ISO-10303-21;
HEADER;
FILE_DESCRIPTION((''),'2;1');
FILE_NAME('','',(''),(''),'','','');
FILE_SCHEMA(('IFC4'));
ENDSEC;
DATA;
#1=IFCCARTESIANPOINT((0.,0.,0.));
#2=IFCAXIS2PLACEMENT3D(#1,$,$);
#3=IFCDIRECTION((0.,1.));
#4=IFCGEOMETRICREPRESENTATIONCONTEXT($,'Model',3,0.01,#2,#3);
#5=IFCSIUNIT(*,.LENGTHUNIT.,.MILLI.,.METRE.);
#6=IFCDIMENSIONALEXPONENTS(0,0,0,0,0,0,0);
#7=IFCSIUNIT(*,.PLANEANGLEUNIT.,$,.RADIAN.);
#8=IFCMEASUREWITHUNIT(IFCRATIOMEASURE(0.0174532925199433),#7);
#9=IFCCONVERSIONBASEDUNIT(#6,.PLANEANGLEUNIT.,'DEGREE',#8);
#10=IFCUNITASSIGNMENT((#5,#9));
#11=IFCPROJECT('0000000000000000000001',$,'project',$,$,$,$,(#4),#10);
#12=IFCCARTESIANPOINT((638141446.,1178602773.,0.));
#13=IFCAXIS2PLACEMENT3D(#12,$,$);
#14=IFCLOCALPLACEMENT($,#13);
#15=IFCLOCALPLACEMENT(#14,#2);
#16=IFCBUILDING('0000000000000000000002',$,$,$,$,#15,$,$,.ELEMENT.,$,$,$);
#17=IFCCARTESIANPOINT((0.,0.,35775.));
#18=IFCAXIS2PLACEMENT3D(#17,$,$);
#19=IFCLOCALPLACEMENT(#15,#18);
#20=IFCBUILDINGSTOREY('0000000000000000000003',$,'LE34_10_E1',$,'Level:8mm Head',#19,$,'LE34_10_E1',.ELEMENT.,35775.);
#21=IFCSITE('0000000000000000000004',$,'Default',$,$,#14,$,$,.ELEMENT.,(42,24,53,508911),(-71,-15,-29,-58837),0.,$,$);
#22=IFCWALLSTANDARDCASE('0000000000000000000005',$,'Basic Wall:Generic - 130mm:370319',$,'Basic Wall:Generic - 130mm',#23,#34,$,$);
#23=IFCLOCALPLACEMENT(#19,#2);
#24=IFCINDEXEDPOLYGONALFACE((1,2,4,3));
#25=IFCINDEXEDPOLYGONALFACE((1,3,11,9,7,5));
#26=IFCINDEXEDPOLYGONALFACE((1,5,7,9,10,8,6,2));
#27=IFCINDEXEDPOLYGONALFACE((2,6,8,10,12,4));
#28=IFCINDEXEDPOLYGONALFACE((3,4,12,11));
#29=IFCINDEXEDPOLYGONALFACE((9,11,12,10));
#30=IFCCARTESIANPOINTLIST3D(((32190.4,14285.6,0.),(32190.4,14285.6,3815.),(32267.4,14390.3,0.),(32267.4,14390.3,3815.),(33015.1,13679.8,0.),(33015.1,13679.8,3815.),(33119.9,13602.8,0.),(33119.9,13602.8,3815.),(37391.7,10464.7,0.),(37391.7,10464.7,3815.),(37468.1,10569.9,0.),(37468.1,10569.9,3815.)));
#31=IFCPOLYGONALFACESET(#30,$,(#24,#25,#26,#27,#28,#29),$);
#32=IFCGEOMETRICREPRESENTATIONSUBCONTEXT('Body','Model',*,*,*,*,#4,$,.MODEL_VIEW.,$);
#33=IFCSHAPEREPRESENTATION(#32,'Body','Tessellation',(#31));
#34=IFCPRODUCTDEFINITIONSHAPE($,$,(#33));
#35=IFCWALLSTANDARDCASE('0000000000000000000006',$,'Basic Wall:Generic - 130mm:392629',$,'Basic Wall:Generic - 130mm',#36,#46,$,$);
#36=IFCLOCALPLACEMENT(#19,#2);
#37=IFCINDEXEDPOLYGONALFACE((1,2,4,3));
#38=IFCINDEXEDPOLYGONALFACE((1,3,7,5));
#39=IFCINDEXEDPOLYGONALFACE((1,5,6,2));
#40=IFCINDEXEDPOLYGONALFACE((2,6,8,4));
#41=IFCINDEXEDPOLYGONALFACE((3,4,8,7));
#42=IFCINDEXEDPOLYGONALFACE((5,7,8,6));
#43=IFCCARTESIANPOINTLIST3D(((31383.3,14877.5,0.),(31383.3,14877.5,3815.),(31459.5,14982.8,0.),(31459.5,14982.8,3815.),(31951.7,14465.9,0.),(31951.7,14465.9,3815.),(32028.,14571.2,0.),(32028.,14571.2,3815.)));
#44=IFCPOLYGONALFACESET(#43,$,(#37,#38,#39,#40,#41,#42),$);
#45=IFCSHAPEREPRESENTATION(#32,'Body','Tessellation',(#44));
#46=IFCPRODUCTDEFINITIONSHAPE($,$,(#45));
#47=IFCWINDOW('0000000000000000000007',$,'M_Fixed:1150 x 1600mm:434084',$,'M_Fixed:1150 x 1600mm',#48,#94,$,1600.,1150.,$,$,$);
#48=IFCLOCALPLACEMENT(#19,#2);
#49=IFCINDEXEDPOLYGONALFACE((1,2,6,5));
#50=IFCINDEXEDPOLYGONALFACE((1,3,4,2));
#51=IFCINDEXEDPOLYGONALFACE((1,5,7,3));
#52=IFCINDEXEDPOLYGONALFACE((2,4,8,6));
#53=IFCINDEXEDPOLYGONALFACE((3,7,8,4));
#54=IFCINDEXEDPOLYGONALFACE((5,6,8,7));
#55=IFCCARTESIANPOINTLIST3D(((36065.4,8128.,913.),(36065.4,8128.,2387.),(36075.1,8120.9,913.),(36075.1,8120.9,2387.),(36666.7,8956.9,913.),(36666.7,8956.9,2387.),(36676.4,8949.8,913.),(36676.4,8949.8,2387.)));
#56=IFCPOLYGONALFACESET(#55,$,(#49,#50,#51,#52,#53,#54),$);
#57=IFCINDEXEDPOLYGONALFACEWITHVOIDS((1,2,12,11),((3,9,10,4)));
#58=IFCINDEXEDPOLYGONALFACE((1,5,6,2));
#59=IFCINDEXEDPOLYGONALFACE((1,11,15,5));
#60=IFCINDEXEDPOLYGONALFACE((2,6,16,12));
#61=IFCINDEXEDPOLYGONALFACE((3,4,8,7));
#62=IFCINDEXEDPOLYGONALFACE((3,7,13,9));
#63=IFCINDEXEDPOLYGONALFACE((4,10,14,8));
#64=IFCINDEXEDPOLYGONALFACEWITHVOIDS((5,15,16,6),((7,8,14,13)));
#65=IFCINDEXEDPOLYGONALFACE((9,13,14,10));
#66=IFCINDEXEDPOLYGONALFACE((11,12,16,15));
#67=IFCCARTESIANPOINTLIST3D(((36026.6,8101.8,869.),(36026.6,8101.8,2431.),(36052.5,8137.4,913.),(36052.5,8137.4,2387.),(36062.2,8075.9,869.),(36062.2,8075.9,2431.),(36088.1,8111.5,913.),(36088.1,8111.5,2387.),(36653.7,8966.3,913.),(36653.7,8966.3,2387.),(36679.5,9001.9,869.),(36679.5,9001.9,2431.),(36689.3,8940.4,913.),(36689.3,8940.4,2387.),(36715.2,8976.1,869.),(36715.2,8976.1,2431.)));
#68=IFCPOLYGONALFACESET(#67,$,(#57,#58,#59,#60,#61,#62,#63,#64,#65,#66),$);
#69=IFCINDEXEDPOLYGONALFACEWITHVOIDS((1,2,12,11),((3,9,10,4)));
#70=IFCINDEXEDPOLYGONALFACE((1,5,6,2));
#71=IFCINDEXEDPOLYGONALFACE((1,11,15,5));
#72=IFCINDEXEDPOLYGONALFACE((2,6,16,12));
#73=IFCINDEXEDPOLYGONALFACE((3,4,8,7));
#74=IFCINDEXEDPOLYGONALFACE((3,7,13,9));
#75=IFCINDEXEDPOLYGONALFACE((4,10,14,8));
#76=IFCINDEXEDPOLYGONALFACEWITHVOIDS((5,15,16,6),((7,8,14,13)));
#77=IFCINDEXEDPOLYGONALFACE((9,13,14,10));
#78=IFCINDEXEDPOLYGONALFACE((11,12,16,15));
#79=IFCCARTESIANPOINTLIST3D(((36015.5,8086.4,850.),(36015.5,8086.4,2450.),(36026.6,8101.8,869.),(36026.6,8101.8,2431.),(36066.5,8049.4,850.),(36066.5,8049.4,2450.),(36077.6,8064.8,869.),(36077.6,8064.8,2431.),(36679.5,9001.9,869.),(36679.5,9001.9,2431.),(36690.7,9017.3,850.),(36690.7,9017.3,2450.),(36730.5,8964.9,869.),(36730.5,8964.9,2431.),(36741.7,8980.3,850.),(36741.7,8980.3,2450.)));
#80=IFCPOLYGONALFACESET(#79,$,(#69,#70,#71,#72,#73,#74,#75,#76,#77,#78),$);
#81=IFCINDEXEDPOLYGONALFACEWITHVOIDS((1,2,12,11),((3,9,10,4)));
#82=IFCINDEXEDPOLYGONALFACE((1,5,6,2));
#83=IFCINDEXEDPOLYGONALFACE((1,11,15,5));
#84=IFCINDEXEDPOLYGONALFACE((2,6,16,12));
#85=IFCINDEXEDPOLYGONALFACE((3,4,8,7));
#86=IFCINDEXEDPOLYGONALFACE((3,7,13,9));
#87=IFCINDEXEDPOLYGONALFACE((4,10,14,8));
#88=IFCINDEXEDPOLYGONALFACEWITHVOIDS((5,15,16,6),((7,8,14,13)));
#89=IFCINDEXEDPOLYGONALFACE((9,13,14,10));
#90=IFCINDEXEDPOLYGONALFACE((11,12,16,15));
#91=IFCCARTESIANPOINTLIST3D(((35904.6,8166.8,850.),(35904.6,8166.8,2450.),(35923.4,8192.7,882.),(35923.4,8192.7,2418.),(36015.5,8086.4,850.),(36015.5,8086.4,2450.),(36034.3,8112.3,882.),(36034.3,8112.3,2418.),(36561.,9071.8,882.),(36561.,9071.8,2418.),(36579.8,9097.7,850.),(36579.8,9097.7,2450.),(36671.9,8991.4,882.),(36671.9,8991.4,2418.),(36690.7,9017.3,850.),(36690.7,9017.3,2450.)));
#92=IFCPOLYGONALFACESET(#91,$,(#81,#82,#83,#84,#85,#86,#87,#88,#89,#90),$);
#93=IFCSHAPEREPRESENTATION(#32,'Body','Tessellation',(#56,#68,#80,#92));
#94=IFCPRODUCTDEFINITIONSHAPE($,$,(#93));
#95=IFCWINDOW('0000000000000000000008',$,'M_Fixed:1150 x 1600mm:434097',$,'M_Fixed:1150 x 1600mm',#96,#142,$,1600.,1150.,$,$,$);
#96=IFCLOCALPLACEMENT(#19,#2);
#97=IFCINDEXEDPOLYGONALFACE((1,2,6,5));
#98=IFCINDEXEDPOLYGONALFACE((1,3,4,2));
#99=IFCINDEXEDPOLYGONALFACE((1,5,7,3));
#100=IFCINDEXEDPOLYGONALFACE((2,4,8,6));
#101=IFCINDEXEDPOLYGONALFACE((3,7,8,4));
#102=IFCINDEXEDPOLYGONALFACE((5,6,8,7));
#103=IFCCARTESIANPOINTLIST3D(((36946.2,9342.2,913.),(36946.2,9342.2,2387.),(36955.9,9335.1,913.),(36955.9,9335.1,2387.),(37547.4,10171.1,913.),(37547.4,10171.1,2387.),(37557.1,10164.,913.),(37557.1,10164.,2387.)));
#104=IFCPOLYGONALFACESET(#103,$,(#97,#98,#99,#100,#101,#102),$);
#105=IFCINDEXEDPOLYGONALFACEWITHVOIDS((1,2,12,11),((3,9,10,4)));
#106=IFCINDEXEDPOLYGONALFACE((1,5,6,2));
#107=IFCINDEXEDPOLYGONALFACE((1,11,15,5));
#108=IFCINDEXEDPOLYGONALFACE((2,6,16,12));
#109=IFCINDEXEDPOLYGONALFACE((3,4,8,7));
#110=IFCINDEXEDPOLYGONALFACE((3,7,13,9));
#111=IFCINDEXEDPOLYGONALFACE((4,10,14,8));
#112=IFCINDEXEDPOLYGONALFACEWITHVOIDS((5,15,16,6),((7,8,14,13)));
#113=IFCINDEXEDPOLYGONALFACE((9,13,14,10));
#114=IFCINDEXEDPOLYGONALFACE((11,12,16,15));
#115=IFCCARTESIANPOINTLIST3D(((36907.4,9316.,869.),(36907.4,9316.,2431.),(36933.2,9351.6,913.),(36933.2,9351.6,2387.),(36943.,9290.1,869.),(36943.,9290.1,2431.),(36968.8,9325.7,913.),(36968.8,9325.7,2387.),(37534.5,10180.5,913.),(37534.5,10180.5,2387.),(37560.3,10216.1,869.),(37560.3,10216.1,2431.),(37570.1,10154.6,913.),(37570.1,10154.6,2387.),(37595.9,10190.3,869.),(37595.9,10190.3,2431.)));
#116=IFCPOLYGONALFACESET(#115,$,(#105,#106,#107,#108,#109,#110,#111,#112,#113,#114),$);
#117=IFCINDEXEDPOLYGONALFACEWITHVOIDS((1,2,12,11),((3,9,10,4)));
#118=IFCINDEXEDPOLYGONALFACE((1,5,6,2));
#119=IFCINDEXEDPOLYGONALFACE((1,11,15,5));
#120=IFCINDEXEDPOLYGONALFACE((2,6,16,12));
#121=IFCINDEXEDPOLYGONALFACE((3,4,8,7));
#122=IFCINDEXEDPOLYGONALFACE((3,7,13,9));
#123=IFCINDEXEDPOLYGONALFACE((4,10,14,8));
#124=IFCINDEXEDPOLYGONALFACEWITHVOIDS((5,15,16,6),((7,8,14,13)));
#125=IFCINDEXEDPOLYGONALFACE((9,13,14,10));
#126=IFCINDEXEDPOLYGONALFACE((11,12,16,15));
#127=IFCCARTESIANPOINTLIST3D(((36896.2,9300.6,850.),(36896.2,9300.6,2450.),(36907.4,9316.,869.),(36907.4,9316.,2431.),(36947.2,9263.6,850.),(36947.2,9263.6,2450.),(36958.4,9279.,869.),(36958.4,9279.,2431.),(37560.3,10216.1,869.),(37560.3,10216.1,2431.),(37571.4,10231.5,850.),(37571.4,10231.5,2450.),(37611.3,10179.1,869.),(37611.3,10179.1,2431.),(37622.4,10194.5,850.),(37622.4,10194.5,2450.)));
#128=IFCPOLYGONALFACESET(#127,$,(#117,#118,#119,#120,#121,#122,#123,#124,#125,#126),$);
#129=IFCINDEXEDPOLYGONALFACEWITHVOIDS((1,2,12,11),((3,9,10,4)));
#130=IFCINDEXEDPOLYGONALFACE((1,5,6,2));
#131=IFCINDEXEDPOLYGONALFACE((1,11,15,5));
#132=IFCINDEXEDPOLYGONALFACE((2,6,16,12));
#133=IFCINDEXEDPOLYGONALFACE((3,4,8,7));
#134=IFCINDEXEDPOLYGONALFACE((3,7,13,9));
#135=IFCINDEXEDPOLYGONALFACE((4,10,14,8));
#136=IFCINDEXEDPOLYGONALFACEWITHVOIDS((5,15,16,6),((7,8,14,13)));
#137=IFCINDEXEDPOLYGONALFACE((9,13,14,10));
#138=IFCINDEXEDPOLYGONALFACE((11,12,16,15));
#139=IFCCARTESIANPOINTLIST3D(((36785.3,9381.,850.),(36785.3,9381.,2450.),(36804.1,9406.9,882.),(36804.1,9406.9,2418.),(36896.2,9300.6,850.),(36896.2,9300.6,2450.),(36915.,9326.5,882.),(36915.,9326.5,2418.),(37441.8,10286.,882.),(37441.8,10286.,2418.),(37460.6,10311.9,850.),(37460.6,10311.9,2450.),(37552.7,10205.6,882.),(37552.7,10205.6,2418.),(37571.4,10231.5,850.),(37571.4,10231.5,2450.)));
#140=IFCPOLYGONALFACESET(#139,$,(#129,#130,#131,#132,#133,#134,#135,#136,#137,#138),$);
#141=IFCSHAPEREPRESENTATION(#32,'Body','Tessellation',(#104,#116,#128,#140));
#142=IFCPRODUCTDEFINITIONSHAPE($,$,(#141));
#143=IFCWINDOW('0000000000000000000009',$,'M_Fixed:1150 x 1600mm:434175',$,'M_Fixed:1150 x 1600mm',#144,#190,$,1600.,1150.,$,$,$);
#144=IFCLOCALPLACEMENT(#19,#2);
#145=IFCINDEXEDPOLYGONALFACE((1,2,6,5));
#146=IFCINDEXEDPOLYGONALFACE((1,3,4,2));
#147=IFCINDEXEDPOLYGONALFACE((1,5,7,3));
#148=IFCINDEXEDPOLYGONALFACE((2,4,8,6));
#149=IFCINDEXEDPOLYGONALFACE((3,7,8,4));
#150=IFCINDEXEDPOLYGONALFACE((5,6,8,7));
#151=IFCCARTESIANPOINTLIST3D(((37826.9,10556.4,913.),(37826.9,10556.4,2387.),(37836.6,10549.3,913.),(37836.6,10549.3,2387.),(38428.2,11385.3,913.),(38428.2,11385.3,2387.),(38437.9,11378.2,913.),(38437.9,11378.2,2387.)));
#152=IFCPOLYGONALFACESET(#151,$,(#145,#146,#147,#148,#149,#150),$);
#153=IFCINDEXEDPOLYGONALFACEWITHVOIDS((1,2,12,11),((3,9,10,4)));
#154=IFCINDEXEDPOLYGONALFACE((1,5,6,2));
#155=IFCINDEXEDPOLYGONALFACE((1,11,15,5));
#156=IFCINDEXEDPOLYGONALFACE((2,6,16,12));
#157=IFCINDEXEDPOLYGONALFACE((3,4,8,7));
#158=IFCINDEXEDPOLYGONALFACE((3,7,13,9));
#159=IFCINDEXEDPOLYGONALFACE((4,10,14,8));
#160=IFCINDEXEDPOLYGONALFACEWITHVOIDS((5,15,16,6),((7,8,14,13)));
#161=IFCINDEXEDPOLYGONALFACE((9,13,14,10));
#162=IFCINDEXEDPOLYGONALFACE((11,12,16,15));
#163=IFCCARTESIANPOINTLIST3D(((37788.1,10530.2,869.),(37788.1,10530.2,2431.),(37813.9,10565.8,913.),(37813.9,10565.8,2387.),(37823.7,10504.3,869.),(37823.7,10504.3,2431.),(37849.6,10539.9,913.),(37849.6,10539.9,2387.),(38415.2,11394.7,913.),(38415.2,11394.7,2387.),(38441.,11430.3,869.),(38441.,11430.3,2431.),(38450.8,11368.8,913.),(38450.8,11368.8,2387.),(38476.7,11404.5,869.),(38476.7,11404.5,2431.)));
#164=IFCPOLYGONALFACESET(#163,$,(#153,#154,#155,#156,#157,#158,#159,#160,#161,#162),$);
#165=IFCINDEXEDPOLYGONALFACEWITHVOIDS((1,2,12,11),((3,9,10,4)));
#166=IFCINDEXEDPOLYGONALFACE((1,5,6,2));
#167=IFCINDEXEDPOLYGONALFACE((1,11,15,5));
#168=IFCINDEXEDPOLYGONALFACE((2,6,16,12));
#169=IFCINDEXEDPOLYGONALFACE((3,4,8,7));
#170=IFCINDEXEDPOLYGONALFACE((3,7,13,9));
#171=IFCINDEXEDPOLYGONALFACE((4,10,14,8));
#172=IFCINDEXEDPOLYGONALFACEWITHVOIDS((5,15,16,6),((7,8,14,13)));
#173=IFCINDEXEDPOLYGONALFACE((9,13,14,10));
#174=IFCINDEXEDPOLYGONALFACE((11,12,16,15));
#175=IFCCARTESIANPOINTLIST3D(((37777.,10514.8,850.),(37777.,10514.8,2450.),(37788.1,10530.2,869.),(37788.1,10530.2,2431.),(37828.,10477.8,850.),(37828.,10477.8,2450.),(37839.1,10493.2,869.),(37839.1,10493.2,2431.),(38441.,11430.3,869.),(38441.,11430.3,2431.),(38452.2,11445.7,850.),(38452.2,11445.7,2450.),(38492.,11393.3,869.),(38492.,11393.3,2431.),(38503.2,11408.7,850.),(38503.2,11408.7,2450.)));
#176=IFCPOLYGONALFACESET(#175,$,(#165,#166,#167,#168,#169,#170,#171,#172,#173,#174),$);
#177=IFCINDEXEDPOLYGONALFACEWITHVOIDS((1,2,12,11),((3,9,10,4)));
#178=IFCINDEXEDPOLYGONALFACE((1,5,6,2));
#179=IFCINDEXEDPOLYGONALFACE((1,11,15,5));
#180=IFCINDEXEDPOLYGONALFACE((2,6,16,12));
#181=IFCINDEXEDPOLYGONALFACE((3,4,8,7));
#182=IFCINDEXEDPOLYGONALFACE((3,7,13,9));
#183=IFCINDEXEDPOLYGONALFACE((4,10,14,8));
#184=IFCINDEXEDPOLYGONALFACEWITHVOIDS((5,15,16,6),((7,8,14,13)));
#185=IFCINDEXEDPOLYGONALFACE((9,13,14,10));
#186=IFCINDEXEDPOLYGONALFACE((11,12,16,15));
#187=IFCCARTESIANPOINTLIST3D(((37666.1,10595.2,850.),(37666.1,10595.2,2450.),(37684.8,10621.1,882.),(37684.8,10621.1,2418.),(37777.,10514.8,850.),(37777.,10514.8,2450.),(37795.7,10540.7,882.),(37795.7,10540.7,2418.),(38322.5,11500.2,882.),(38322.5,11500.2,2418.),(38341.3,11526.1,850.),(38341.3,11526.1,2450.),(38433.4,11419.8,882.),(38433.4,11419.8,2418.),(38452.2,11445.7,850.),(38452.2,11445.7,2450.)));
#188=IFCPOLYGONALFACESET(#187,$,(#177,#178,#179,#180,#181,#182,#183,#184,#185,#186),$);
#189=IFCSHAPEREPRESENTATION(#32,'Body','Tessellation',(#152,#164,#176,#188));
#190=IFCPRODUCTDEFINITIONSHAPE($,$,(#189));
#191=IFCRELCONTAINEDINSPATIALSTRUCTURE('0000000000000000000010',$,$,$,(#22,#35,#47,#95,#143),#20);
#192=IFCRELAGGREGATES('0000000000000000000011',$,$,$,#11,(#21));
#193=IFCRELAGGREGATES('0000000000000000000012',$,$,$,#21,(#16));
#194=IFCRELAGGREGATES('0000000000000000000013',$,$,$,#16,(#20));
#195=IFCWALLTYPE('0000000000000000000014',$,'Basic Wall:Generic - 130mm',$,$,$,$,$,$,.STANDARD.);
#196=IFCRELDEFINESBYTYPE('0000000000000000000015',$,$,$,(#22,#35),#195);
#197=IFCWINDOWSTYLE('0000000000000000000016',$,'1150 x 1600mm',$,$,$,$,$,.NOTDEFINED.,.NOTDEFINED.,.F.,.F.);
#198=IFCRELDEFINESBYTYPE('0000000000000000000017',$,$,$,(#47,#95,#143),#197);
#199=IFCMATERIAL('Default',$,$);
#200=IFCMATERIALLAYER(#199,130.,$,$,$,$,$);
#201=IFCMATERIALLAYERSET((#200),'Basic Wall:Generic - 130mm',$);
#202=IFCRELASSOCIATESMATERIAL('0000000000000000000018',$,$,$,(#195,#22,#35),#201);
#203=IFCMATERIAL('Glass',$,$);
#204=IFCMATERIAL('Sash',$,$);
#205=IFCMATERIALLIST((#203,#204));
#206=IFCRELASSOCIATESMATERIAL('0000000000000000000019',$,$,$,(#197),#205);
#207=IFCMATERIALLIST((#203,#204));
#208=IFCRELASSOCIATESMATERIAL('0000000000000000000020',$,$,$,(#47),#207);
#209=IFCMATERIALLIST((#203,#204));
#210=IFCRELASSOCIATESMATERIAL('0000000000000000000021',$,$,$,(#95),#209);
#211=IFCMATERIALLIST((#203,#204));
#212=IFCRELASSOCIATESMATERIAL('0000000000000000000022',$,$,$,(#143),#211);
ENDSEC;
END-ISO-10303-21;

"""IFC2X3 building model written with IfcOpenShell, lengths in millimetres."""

from ifc_helpers import new_model, entity, si_unit, converted_unit, direction, frame, frame_2d, origin, place, context, subcontext, project, spatial, polyline, rectangle, outline, extrude, source, transform, mapped, material, material_list, layer, layer_set, layer_usage, type_object, type_shapes, element, save


model = new_model("IFC2X3")

# Units and contexts
model_context = context("Model", 3, precision=0.01, world=origin(), true_north=direction((0.0, 1.0)))
body_context = subcontext(model_context, "Body", "Model", "MODEL_VIEW")
ifc_project = project(units=[si_unit("LENGTHUNIT", "METRE", prefix="MILLI"), converted_unit("PLANEANGLEUNIT", "DEGREE", entity("IfcRatioMeasure", 0.0174532925199433), si_unit("PLANEANGLEUNIT", "RADIAN"), dimensions=[0, 0, 0, 0, 0, 0, 0])], contexts=[model_context])

# Site, building, storey
site_placement = place(None, frame((638141446.0, 1178602773.0, 0.0)))
site = spatial("IfcSite", under=ifc_project, at=site_placement, Name="Default", CompositionType="ELEMENT", RefLatitude=(42, 24, 53, 508911), RefLongitude=(-71, -15, -29, -58837), RefElevation=0.0)
building_placement = place(site_placement, origin())
building = spatial("IfcBuilding", under=site, at=building_placement, CompositionType="ELEMENT")
storey_placement = place(building_placement, frame((0.0, 0.0, 35775.0)))
storey = spatial("IfcBuildingStorey", under=building, at=storey_placement, Name="LE34_10_E1", ObjectType="Level:8mm Head", LongName="LE34_10_E1", CompositionType="ELEMENT", Elevation=35775.0)

# Walls
ifc_material_1 = material(Name="Default")
ifc_layer_1 = layer(ifc_material_1, 130.0)
ifc_layer_set_1 = layer_set([ifc_layer_1], Name="Basic Wall:Generic - 130mm")
ifc_layer_usage_1 = layer_usage(ifc_layer_set_1, "AXIS2", "NEGATIVE", 65.0)
wall_type_1 = type_object("IfcWallType", Name="Basic Wall:Generic - 130mm", PredefinedType="STANDARD", material=ifc_layer_set_1)
wall_1_placement = place(storey_placement, frame((32228.9, 14338.0, 0.0), z_axis=(0.0, 0.0, 1.0), x_axis=(0.805916, -0.592029, 0.0)))
element("IfcWallStandardCase", 1, at=wall_1_placement, inside=storey, type_object=wall_type_1, material=ifc_layer_usage_1, Name="Basic Wall:Generic - 130mm:370319", ObjectType="Basic Wall:Generic - 130mm", context=body_context, shape_type="SweptSolid", body=[
    extrude(outline(polyline([(6453.9, -65.0), (6453.1, 65.0), (0.0, 65.0), (0.0, -65.0), (1023.3, -65.0), (1153.3, -65.0), (6453.9, -65.0)])), origin(), (0.0, 0.0, 1.0), 3815.0),
])
ifc_layer_usage_2 = layer_usage(ifc_layer_set_1, "AXIS2", "NEGATIVE", 65.0)
wall_2_placement = place(storey_placement, frame((31421.4, 14930.1, 0.0), z_axis=(0.0, 0.0, 1.0), x_axis=(0.809972, -0.586469, 0.0)))
element("IfcWallStandardCase", 2, at=wall_2_placement, inside=storey, type_object=wall_type_1, material=ifc_layer_usage_2, Name="Basic Wall:Generic - 130mm:392629", ObjectType="Basic Wall:Generic - 130mm", context=body_context, shape_type="SweptSolid", body=[
    extrude(rectangle(XDim=701.8, YDim=130.0, at=frame_2d((350.9, 0.0), x_axis=(-1.0, 0.0))), origin(), (0.0, 0.0, 1.0), 3815.0),
])

# Windows
ifc_material_2 = material(Name="Glass")
ifc_material_3 = material(Name="Sash")
ifc_material_list_1 = material_list([ifc_material_2, ifc_material_3])
ifc_material_list_2 = material_list([ifc_material_2, ifc_material_3])
window_style = type_object("IfcWindowStyle", Name="1150 x 1600mm", ConstructionType="NOTDEFINED", OperationType="NOTDEFINED", ParameterTakesPrecedence=False, Sizeable=False, material=ifc_material_list_2)
shared_shape = source(origin(), body_context, "Body", "SweptSolid", [
    extrude(rectangle(XDim=1024.0, YDim=12.0, at=frame_2d((0.0, 0.0), x_axis=(1.0, 0.0))), frame((575.0, 295.0, 63.0), z_axis=(0.0, 0.0, 1.0), x_axis=(-1.0, 0.0, 0.0)), (0.0, 0.0, 1.0), 1474.0),
    extrude(outline(polyline([(-556.0, -781.0), (556.0, -781.0), (556.0, 781.0), (-556.0, 781.0), (-556.0, -781.0)]), holes=[polyline([(-512.0, -737.0), (-512.0, 737.0), (512.0, 737.0), (512.0, -737.0), (-512.0, -737.0)])]), frame((575.0, 317.0, 800.0), z_axis=(0.0, -1.0, 0.0), x_axis=(-1.0, 0.0, 0.0)), (0.0, 0.0, 1.0), 44.0),
    extrude(outline(polyline([(-575.0, -800.0), (575.0, -800.0), (575.0, 800.0), (-575.0, 800.0), (-575.0, -800.0)]), holes=[polyline([(-556.0, -781.0), (-556.0, 781.0), (556.0, 781.0), (556.0, -781.0), (-556.0, -781.0)])]), frame((575.0, 336.0, 800.0), z_axis=(0.0, -1.0, 0.0), x_axis=(-1.0, 0.0, 0.0)), (0.0, 0.0, 1.0), 63.0),
    extrude(outline(polyline([(-575.0, -800.0), (575.0, -800.0), (575.0, 800.0), (-575.0, 800.0), (-575.0, -800.0)]), holes=[polyline([(-543.0, -768.0), (-543.0, 768.0), (543.0, 768.0), (543.0, -768.0), (-543.0, -768.0)])]), frame((575.0, 273.0, 800.0), z_axis=(0.0, -1.0, 0.0), x_axis=(-1.0, 0.0, 0.0)), (0.0, 0.0, 1.0), 137.0),
])
type_shapes(window_style, [shared_shape])
window_1_placement = place(storey_placement, frame((36469.7, 9177.6, 850.0), z_axis=(0.0, 0.0, 1.0), x_axis=(-0.587164, -0.809468, 0.0)))
element("IfcWindow", 3, at=window_1_placement, inside=storey, type_object=window_style, material=ifc_material_list_1, Name="M_Fixed:1150 x 1600mm:434084", ObjectType="M_Fixed:1150 x 1600mm", OverallHeight=1600.0, OverallWidth=1150.0, context=body_context, shape_type="MappedRepresentation", body=[
    mapped(shared_shape, transform((0.0, 0.0, 0.0), scale=1.0)),
])
ifc_material_list_3 = material_list([ifc_material_2, ifc_material_3])
window_2_placement = place(storey_placement, frame((37350.5, 10391.8, 850.0), z_axis=(0.0, 0.0, 1.0), x_axis=(-0.587164, -0.809468, 0.0)))
element("IfcWindow", 4, at=window_2_placement, inside=storey, type_object=window_style, material=ifc_material_list_3, Name="M_Fixed:1150 x 1600mm:434097", ObjectType="M_Fixed:1150 x 1600mm", OverallHeight=1600.0, OverallWidth=1150.0, context=body_context, shape_type="MappedRepresentation", body=[
    mapped(shared_shape, transform((0.0, 0.0, 0.0), scale=1.0)),
])
ifc_material_list_4 = material_list([ifc_material_2, ifc_material_3])
window_3_placement = place(storey_placement, frame((38231.2, 11606.0, 850.0), z_axis=(0.0, 0.0, 1.0), x_axis=(-0.587164, -0.809468, 0.0)))
element("IfcWindow", 5, at=window_3_placement, inside=storey, type_object=window_style, material=ifc_material_list_4, Name="M_Fixed:1150 x 1600mm:434175", ObjectType="M_Fixed:1150 x 1600mm", OverallHeight=1600.0, OverallWidth=1150.0, context=body_context, shape_type="MappedRepresentation", body=[
    mapped(shared_shape, transform((0.0, 0.0, 0.0), scale=1.0)),
])

save(model, "model.ifc")
